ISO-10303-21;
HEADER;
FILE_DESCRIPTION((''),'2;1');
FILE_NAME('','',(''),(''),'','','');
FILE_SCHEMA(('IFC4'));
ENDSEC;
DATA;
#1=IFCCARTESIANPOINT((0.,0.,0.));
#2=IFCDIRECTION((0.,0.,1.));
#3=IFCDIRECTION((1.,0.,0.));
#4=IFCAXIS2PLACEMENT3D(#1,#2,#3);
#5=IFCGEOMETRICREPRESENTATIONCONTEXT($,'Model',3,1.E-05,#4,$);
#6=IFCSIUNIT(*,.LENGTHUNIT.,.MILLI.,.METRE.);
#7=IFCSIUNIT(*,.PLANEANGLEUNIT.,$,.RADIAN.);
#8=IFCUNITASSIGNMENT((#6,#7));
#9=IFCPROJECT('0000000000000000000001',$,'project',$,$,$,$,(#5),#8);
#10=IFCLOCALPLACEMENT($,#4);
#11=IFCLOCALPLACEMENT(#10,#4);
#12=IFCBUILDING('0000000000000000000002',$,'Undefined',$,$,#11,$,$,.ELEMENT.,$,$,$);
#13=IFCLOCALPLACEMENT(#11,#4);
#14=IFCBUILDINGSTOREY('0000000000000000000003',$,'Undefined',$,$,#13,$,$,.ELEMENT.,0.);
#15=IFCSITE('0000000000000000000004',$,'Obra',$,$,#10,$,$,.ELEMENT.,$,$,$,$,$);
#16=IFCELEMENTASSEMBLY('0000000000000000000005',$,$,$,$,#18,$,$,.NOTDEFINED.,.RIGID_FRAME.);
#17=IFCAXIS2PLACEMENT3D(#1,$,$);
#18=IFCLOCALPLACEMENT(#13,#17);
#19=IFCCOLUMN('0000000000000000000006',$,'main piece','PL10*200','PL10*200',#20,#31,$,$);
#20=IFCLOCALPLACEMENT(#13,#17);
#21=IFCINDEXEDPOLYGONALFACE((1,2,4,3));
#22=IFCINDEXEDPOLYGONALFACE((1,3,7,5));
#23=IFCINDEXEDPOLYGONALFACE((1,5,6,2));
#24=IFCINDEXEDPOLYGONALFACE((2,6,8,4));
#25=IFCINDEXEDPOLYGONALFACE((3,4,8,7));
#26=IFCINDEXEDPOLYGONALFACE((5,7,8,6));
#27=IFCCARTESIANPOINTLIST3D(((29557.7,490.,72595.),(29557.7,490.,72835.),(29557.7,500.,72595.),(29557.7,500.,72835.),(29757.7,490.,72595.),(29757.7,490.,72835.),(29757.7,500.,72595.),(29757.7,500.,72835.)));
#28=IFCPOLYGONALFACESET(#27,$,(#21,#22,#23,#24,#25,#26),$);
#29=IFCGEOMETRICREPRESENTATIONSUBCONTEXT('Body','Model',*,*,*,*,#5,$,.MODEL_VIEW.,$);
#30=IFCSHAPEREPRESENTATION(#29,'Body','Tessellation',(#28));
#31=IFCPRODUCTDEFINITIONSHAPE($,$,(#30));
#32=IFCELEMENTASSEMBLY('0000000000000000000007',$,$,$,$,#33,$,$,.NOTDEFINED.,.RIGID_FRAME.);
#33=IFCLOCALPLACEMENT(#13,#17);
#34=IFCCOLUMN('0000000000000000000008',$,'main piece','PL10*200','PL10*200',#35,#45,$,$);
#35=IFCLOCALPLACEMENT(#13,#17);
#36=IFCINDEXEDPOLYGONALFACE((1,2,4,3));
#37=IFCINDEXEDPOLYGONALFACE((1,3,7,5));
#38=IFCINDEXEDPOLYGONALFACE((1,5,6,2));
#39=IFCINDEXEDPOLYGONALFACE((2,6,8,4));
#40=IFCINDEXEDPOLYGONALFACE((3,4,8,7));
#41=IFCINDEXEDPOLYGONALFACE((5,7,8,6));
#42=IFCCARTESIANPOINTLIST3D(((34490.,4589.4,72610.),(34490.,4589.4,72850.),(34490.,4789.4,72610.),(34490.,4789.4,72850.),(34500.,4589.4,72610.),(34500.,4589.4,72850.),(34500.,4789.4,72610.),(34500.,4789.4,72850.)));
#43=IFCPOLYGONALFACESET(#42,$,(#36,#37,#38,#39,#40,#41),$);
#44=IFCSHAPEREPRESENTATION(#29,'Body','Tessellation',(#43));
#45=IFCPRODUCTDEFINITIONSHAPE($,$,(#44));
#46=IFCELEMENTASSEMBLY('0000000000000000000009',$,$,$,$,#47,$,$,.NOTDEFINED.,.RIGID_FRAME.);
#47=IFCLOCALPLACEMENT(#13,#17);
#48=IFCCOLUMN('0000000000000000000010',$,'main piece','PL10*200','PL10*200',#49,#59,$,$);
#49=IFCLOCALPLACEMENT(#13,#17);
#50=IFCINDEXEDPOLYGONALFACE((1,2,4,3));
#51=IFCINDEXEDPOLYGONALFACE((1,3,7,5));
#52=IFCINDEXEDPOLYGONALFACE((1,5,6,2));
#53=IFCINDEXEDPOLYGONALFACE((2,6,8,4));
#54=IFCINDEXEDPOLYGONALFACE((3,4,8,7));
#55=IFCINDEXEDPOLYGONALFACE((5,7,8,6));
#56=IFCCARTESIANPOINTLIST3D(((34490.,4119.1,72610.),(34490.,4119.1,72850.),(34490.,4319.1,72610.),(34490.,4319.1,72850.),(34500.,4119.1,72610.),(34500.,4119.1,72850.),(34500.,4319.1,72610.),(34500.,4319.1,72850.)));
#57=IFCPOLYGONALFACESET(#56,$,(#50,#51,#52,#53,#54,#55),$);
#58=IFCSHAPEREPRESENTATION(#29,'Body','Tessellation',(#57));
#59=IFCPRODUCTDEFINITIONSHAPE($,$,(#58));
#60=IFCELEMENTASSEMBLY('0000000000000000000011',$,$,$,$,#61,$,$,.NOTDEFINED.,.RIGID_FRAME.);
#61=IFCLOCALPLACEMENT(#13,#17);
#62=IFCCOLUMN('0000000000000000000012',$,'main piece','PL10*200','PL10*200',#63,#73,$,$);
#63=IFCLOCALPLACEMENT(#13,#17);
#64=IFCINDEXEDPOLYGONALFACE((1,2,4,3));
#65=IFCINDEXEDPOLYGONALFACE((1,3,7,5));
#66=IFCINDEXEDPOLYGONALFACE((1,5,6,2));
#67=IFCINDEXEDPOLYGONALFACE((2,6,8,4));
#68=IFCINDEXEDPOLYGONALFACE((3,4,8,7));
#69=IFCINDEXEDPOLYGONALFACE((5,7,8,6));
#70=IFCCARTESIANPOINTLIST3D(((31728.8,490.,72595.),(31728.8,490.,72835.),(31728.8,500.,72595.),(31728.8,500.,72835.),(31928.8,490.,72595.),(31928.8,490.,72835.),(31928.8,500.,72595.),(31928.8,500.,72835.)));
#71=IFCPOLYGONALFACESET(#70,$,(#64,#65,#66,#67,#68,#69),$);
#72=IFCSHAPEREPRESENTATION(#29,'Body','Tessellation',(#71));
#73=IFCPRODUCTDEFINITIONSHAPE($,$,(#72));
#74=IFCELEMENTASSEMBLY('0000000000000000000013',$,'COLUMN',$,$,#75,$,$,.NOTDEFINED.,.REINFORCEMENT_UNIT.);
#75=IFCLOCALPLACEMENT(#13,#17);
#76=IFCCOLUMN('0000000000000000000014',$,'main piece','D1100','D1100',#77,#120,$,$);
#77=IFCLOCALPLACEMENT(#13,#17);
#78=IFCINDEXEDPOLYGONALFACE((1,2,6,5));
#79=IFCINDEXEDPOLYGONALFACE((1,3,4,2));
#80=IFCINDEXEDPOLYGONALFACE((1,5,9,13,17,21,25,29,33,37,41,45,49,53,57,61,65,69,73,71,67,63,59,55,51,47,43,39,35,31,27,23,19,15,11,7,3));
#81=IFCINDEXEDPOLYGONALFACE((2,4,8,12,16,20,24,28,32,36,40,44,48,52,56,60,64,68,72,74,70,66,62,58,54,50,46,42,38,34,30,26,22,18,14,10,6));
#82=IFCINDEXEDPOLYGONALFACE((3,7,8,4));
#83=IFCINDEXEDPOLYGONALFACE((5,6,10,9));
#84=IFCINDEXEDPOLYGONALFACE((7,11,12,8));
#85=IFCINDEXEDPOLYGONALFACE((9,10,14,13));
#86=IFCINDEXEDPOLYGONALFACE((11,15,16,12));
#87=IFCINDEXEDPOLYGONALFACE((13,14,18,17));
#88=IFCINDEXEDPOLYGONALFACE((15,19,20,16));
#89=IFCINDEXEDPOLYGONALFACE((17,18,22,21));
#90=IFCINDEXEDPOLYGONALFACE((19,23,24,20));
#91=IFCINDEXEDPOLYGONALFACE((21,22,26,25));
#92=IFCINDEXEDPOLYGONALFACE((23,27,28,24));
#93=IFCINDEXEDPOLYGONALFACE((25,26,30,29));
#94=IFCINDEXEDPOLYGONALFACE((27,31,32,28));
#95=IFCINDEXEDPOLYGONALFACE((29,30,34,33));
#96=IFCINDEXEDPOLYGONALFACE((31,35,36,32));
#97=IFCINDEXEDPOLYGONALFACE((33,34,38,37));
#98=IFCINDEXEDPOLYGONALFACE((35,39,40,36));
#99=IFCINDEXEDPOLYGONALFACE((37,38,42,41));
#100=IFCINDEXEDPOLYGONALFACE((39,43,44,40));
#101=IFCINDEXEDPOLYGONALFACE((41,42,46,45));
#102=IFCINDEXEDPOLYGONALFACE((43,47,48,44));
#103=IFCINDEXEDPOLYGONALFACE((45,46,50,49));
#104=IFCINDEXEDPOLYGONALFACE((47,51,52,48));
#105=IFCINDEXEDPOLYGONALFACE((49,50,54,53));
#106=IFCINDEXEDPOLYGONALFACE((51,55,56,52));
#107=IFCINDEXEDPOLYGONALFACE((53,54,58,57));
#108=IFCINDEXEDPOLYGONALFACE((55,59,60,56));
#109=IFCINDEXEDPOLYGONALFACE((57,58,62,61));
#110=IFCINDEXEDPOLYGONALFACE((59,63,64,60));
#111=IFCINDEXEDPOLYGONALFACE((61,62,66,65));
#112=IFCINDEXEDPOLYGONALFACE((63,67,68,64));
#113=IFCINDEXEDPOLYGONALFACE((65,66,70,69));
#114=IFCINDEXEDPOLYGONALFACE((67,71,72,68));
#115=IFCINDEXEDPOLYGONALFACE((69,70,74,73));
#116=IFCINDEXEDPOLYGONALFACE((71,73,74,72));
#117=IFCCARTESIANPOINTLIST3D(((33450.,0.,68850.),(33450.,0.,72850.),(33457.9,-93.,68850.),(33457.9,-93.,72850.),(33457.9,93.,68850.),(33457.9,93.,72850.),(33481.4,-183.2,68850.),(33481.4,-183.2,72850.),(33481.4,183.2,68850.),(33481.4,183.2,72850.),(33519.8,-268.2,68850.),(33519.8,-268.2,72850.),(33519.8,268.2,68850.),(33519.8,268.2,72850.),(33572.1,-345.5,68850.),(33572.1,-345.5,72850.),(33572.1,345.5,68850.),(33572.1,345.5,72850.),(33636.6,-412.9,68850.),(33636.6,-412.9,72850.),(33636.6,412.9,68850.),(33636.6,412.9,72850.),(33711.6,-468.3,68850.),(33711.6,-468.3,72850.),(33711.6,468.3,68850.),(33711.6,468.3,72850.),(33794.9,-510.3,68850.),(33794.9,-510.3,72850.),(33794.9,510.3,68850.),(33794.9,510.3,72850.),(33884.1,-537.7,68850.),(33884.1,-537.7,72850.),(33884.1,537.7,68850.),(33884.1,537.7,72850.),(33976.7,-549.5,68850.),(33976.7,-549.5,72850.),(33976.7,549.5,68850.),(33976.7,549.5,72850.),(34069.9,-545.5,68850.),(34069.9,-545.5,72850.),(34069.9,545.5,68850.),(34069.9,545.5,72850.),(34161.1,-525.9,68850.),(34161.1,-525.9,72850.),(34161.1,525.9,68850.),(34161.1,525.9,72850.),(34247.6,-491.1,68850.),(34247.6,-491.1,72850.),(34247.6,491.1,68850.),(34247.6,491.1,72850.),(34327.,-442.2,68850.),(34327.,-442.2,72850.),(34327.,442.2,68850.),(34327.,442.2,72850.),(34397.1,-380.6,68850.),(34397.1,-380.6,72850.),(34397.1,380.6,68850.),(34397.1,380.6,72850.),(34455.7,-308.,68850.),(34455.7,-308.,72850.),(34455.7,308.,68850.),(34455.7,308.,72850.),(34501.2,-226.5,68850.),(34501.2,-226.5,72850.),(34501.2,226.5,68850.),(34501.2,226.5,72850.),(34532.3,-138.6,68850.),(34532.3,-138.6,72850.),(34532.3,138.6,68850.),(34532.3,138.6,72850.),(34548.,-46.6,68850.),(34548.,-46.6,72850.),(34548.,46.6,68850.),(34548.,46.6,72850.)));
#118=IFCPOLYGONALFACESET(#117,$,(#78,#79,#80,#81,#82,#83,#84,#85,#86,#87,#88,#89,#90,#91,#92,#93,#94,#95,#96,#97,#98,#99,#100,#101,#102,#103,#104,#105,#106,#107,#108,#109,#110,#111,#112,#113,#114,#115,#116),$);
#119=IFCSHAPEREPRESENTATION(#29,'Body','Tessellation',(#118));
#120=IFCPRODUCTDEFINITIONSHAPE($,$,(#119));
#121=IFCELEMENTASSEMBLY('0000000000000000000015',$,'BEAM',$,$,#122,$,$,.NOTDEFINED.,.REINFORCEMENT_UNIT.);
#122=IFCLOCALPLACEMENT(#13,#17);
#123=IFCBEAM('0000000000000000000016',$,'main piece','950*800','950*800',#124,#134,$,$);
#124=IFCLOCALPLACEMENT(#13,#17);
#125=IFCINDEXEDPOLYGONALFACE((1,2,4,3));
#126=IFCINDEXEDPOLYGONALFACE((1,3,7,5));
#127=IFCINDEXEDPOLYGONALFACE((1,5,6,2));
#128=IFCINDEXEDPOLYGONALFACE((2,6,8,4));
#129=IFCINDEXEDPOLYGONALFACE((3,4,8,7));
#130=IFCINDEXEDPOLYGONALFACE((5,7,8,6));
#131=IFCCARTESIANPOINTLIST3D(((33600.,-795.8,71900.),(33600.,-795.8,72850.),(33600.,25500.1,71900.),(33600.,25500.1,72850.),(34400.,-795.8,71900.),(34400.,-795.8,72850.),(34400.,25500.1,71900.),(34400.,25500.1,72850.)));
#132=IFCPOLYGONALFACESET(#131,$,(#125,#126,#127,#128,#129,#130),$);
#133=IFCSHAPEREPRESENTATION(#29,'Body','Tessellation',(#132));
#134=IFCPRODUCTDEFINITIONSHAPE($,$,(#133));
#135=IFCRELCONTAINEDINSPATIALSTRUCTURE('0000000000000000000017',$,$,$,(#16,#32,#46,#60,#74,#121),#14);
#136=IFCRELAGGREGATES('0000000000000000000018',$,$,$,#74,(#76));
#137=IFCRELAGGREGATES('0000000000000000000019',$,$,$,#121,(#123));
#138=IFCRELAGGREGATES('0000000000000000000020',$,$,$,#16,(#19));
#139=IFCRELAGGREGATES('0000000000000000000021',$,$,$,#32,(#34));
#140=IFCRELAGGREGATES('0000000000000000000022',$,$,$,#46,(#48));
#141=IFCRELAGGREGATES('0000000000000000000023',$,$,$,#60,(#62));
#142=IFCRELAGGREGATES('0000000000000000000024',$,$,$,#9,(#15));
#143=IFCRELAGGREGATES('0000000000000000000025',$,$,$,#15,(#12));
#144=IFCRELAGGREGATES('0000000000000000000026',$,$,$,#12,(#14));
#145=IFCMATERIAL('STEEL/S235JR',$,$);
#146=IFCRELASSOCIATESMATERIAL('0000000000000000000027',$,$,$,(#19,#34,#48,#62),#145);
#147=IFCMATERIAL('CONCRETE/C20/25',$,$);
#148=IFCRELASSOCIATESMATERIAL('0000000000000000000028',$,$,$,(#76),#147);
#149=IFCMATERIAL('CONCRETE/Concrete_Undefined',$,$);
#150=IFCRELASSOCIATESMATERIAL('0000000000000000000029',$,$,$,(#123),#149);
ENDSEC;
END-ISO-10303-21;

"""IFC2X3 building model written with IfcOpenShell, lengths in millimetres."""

from ifc_helpers import new_model, si_unit, frame, origin_with_axes, origin_2d_with_axis, place, context, subcontext, project, spatial, rectangle, circle, extrude, material, element, aggregate, save


model = new_model("IFC2X3")

# Units and contexts
model_context = context("Model", 3, precision=1e-05, world=origin_with_axes())
body_context = subcontext(model_context, "Body", "Model", "MODEL_VIEW")
ifc_project = project(units=[si_unit("LENGTHUNIT", "METRE", prefix="MILLI"), si_unit("PLANEANGLEUNIT", "RADIAN")], contexts=[model_context])

# Site, building, storey
site_placement = place(None, origin_with_axes())
site = spatial("IfcSite", under=ifc_project, at=site_placement, Name="Obra", CompositionType="ELEMENT")
building_placement = place(site_placement, origin_with_axes())
building = spatial("IfcBuilding", under=site, at=building_placement, Name="Undefined", CompositionType="ELEMENT")
storey_placement = place(building_placement, origin_with_axes())
storey = spatial("IfcBuildingStorey", under=building, at=storey_placement, Name="Undefined", CompositionType="ELEMENT", Elevation=0.0)

# Element assemblies, columns
assembly_1_placement = place(storey_placement, origin_with_axes())
assembly_1 = element("IfcElementAssembly", 1, at=assembly_1_placement, inside=storey, AssemblyPlace="NOTDEFINED", PredefinedType="RIGID_FRAME")
ifc_material_1 = material(Name="STEEL/S235JR")
column_1_placement = place(assembly_1_placement, frame((29657.7, 495.0, 72595.0), z_axis=(0.0, 0.0, 1.0), x_axis=(1.0, 0.000002, 0.0)))
column_1 = element("IfcColumn", 2, at=column_1_placement, material=ifc_material_1, Name="main piece", Description="PL10*200", ObjectType="PL10*200", context=body_context, shape_type="SweptSolid", body=[
    extrude(rectangle(XDim=10.0, YDim=200.0, at=origin_2d_with_axis()), frame((0.0, 0.0, 240.0), z_axis=(0.0, 0.0, -1.0), x_axis=(0.0, 1.0, 0.0)), (0.0, 0.0, 1.0), 240.0),
])
assembly_2_placement = place(storey_placement, origin_with_axes())
assembly_2 = element("IfcElementAssembly", 3, at=assembly_2_placement, inside=storey, AssemblyPlace="NOTDEFINED", PredefinedType="RIGID_FRAME")
column_2_placement = place(assembly_2_placement, frame((34495.0, 4689.4, 72610.0), z_axis=(0.0, 0.0, 1.0), x_axis=(0.0, -1.0, 0.0)))
column_2 = element("IfcColumn", 4, at=column_2_placement, material=ifc_material_1, Name="main piece", Description="PL10*200", ObjectType="PL10*200", context=body_context, shape_type="SweptSolid", body=[
    extrude(rectangle(XDim=10.0, YDim=200.0, at=origin_2d_with_axis()), frame((0.0, 0.0, 240.0), z_axis=(0.0, 0.0, -1.0), x_axis=(0.0, 1.0, 0.0)), (0.0, 0.0, 1.0), 240.0),
])
assembly_3_placement = place(storey_placement, origin_with_axes())
assembly_3 = element("IfcElementAssembly", 5, at=assembly_3_placement, inside=storey, AssemblyPlace="NOTDEFINED", PredefinedType="RIGID_FRAME")
column_3_placement = place(assembly_3_placement, frame((34495.0, 4219.1, 72610.0), z_axis=(0.0, 0.0, 1.0), x_axis=(0.0, -1.0, 0.0)))
column_3 = element("IfcColumn", 6, at=column_3_placement, material=ifc_material_1, Name="main piece", Description="PL10*200", ObjectType="PL10*200", context=body_context, shape_type="SweptSolid", body=[
    extrude(rectangle(XDim=10.0, YDim=200.0, at=origin_2d_with_axis()), frame((0.0, 0.0, 240.0), z_axis=(0.0, 0.0, -1.0), x_axis=(0.0, 1.0, 0.0)), (0.0, 0.0, 1.0), 240.0),
])
assembly_4_placement = place(storey_placement, origin_with_axes())
assembly_4 = element("IfcElementAssembly", 7, at=assembly_4_placement, inside=storey, AssemblyPlace="NOTDEFINED", PredefinedType="RIGID_FRAME")
column_4_placement = place(assembly_4_placement, frame((31828.8, 495.0, 72595.0), z_axis=(0.0, 0.0, 1.0), x_axis=(1.0, 0.000002, 0.0)))
column_4 = element("IfcColumn", 8, at=column_4_placement, material=ifc_material_1, Name="main piece", Description="PL10*200", ObjectType="PL10*200", context=body_context, shape_type="SweptSolid", body=[
    extrude(rectangle(XDim=10.0, YDim=200.0, at=origin_2d_with_axis()), frame((0.0, 0.0, 240.0), z_axis=(0.0, 0.0, -1.0), x_axis=(0.0, 1.0, 0.0)), (0.0, 0.0, 1.0), 240.0),
])
assembly_5_placement = place(storey_placement, origin_with_axes())
assembly_5 = element("IfcElementAssembly", 9, at=assembly_5_placement, inside=storey, Name="COLUMN", AssemblyPlace="NOTDEFINED", PredefinedType="REINFORCEMENT_UNIT")
ifc_material_2 = material(Name="CONCRETE/C20/25")
column_5_placement = place(assembly_5_placement, frame((34000.0, 0.0, 68850.0), z_axis=(0.0, 0.0, 1.0), x_axis=(0.0, 1.0, 0.0)))
column_5 = element("IfcColumn", 10, at=column_5_placement, material=ifc_material_2, Name="main piece", Description="D1100", ObjectType="D1100", context=body_context, shape_type="SweptSolid", body=[
    extrude(circle(Radius=550.0, at=origin_2d_with_axis()), frame((0.0, 0.0, 4000.0), z_axis=(0.0, 0.0, -1.0), x_axis=(0.0, 1.0, 0.0)), (0.0, 0.0, 1.0), 4000.0),
])
aggregate(assembly_5, [column_5])

# Element assembly, beam
assembly_6_placement = place(storey_placement, origin_with_axes())
assembly_6 = element("IfcElementAssembly", 11, at=assembly_6_placement, inside=storey, Name="BEAM", AssemblyPlace="NOTDEFINED", PredefinedType="REINFORCEMENT_UNIT")
ifc_material_3 = material(Name="CONCRETE/Concrete_Undefined")
beam_1_placement = place(assembly_6_placement, frame((34000.0, -795.8, 72375.0), z_axis=(0.0, 0.0, 1.0), x_axis=(0.0, 1.0, 0.0)))
beam_1 = element("IfcBeam", 12, at=beam_1_placement, material=ifc_material_3, Name="main piece", Description="950*800", ObjectType="950*800", context=body_context, shape_type="SweptSolid", body=[
    extrude(rectangle(XDim=800.0, YDim=950.0, at=origin_2d_with_axis()), frame((26296.0, 0.0, 0.0), z_axis=(-1.0, 0.0, 0.0), x_axis=(0.0, -1.0, 0.0)), (0.0, 0.0, 1.0), 26296.0),
])
aggregate(assembly_6, [beam_1])

aggregate(assembly_1, [column_1])
aggregate(assembly_2, [column_2])
aggregate(assembly_3, [column_3])
aggregate(assembly_4, [column_4])

save(model, "model.ifc")
